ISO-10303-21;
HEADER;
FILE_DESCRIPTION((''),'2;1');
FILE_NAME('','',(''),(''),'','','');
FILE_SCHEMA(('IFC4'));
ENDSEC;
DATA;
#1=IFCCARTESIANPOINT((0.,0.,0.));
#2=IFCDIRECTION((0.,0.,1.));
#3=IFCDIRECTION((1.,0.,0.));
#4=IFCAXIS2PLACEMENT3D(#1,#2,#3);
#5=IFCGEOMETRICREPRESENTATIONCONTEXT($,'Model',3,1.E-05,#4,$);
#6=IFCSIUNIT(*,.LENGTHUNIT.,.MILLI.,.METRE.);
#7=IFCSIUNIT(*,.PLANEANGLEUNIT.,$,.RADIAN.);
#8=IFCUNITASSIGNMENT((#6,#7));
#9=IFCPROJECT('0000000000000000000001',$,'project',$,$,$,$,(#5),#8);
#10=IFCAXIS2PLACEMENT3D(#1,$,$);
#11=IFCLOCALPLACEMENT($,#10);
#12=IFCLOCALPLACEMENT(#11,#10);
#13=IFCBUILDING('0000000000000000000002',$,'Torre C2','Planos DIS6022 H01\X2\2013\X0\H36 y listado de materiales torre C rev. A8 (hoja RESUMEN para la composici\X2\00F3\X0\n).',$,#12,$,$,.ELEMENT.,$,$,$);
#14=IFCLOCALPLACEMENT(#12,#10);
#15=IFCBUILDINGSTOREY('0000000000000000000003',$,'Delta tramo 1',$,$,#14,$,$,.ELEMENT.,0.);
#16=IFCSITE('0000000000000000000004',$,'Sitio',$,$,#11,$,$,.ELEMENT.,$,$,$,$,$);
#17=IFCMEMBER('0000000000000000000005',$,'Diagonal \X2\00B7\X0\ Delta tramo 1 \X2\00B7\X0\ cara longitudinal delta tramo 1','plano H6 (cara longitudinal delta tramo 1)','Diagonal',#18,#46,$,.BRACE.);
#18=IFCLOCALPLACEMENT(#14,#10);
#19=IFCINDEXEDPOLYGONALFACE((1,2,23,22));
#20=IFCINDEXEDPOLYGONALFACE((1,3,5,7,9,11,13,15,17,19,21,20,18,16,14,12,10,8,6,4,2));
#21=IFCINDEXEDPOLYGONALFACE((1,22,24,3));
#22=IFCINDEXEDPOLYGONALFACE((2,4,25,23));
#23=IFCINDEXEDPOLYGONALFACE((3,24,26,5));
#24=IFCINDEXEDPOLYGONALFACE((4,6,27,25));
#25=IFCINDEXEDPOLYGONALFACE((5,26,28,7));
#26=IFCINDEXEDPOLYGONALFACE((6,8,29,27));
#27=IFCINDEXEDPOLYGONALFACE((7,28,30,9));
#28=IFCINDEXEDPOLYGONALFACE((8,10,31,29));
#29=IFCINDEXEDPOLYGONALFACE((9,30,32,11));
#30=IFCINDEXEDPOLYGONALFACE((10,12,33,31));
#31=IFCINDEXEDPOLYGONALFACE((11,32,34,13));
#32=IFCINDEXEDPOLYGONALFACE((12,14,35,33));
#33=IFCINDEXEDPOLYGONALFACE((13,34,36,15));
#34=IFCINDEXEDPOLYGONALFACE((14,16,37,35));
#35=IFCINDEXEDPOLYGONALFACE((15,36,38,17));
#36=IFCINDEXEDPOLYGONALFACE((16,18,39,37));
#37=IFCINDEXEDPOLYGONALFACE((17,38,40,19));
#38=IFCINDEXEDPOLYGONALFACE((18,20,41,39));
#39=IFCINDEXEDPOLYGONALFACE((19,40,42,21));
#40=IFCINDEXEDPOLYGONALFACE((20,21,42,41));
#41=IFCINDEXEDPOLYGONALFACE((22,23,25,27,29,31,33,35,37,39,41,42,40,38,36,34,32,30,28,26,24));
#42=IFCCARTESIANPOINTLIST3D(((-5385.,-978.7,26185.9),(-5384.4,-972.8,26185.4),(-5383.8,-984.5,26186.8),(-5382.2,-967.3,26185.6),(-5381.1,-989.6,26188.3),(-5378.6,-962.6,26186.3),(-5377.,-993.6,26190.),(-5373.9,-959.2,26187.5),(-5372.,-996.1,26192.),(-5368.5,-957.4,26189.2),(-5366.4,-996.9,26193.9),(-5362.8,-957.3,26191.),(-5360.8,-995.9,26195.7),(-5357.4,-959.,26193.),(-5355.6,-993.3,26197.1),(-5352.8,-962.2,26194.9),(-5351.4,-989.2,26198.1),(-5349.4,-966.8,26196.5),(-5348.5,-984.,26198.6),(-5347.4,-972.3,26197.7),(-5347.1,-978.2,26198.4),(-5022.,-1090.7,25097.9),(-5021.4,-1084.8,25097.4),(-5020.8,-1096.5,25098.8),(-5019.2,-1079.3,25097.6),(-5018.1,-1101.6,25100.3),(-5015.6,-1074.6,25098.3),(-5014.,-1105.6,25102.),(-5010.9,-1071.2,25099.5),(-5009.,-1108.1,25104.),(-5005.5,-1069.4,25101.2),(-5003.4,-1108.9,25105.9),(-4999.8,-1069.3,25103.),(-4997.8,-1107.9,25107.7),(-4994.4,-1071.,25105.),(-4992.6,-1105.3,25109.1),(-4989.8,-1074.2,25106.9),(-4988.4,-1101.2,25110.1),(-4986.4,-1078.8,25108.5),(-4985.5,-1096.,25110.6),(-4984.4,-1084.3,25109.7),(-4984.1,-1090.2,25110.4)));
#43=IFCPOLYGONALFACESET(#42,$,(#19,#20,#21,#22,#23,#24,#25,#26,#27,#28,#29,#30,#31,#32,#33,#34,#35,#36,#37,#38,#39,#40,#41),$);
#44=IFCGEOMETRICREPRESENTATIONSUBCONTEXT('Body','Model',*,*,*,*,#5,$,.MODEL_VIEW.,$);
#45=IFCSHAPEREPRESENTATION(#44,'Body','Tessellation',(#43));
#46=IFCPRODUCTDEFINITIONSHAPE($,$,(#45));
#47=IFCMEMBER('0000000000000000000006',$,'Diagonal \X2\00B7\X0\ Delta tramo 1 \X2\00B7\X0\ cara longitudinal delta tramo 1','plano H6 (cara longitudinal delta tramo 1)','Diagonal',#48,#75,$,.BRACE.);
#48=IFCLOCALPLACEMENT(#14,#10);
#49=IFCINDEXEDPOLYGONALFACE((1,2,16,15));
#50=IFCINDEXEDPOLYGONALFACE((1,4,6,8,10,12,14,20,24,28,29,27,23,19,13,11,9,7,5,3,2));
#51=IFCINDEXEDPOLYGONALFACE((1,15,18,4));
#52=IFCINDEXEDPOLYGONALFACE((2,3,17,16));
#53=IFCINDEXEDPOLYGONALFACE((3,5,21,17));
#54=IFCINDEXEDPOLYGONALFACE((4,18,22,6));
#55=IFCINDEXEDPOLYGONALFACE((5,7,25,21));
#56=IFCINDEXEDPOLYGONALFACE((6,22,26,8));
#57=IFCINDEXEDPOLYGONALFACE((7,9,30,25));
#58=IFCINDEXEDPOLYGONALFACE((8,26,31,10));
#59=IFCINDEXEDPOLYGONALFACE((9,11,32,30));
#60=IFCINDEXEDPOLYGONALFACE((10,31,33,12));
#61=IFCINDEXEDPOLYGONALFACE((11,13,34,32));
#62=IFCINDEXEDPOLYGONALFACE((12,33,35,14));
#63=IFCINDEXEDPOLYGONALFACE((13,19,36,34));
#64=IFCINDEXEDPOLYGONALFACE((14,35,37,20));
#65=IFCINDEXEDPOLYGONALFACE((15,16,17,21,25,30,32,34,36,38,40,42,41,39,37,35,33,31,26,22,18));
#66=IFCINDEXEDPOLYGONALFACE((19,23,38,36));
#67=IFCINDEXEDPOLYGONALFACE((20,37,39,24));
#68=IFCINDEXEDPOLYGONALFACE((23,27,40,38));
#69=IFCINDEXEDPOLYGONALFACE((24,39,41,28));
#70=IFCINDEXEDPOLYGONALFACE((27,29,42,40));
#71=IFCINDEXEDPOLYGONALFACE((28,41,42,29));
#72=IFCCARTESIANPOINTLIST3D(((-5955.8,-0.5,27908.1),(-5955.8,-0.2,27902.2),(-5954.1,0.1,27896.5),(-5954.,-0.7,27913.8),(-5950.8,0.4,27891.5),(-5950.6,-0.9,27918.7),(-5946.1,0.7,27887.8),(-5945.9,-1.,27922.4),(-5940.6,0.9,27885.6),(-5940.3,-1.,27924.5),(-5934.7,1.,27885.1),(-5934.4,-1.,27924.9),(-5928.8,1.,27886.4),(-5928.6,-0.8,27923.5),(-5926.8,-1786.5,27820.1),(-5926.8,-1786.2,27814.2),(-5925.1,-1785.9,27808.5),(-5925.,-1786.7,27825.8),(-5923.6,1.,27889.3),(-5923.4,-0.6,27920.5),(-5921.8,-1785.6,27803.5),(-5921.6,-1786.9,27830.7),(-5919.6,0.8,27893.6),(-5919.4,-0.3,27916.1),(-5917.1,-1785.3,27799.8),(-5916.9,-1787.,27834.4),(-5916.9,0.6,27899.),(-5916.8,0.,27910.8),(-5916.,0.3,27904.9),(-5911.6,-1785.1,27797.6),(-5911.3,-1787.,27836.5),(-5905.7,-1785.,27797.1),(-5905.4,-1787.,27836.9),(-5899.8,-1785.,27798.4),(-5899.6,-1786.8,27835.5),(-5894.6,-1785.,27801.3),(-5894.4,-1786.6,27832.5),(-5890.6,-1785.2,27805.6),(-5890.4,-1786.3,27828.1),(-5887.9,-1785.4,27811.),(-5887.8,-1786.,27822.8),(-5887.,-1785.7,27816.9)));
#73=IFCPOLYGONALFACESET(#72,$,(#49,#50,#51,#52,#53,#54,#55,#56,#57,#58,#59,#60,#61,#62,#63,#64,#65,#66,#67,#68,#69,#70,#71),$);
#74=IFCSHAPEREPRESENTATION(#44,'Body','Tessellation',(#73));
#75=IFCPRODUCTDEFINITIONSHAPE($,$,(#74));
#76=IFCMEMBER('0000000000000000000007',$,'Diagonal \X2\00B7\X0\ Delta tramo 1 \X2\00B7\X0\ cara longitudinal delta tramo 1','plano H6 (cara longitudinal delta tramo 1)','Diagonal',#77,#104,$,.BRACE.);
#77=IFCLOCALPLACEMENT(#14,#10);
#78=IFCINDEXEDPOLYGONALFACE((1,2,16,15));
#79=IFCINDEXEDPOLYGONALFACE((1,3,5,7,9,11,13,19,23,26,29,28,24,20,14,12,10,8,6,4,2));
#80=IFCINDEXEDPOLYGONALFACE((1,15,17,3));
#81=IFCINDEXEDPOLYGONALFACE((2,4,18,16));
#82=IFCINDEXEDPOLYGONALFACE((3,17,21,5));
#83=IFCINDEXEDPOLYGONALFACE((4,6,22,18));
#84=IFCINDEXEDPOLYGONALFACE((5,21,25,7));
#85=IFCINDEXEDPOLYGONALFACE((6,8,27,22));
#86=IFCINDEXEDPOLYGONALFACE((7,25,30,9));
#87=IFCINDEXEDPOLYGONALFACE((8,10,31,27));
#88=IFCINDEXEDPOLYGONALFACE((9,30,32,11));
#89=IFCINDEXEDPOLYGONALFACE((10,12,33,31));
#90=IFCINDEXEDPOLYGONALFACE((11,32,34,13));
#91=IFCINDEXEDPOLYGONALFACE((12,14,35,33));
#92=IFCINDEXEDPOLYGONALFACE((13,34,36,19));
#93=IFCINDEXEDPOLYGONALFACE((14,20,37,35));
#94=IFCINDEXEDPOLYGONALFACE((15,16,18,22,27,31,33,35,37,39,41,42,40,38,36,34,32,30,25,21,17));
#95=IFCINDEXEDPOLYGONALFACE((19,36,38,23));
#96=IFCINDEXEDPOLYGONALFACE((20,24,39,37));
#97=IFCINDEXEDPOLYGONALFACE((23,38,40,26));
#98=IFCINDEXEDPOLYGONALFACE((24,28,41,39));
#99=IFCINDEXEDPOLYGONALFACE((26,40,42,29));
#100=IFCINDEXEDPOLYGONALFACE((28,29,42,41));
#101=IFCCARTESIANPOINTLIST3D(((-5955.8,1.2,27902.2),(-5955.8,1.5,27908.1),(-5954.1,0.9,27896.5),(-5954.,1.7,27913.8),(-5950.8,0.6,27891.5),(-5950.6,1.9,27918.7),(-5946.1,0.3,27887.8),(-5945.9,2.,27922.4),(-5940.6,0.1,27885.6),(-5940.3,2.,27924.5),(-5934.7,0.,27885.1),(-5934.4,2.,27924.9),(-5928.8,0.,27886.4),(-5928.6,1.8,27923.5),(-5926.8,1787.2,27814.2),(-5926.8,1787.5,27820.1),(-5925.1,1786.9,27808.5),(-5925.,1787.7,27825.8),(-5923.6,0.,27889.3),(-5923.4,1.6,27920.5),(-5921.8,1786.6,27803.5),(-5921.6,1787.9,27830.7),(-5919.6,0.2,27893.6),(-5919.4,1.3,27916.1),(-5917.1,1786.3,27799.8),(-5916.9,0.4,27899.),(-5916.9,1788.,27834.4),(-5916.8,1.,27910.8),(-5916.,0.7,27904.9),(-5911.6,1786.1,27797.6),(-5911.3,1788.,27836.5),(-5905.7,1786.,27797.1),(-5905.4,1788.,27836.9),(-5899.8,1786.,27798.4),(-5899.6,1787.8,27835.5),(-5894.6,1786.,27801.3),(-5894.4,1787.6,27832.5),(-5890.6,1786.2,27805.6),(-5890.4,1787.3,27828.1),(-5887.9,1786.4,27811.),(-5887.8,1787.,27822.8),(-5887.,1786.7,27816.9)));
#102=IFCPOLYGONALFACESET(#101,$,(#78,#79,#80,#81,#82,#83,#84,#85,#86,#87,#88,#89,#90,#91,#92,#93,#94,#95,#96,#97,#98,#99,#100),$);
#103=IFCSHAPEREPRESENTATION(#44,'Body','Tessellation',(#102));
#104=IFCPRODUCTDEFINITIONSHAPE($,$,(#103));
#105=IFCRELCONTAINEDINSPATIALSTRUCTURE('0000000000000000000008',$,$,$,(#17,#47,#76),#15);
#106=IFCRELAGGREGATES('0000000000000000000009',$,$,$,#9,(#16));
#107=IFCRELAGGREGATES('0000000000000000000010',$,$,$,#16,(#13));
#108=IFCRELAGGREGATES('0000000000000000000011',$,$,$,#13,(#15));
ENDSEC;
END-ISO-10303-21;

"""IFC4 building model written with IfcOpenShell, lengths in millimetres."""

from ifc_helpers import new_model, si_unit, frame, origin, origin_with_axes, place, context, subcontext, project, spatial, circle, extrude, element, save


model = new_model("IFC4")

# Units and contexts
model_context = context("Model", 3, precision=1e-05, world=origin_with_axes())
body_context = subcontext(model_context, "Body", "Model", "MODEL_VIEW")
ifc_project = project(units=[si_unit("LENGTHUNIT", "METRE", prefix="MILLI"), si_unit("PLANEANGLEUNIT", "RADIAN")], contexts=[model_context])

# Site, building, storey
site_placement = place(None, origin())
site = spatial("IfcSite", under=ifc_project, at=site_placement, Name="Sitio", CompositionType="ELEMENT")
building_placement = place(site_placement, origin())
building = spatial("IfcBuilding", under=site, at=building_placement, Name="Torre C2", Description="Planos DIS6022 H01–H36 y listado de materiales torre C rev. A8 (hoja RESUMEN para la composición).", CompositionType="ELEMENT")
storey_placement = place(building_placement, origin())
storey = spatial("IfcBuildingStorey", under=building, at=storey_placement, Name="Delta tramo 1", CompositionType="ELEMENT", Elevation=0.0)

# Members
member_1_placement = place(storey_placement, frame((-5366.0, -977.0, 26192.0), z_axis=(0.314991, -0.097187, -0.944106), x_axis=(0.929313, 0.233618, 0.286007)))
element("IfcMember", 1, at=member_1_placement, inside=storey, Name="Diagonal · Delta tramo 1 · cara longitudinal delta tramo 1", Description="plano H6 (cara longitudinal delta tramo 1)", ObjectType="Diagonal", PredefinedType="BRACE", context=body_context, shape_type="SweptSolid", body=[
    extrude(circle(Radius=20.0), None, (0.0, 0.0, 1.0), 1152.4),
])
for number, where, z_axis, x_axis, name in (
    (2, (-5936.0, 0.0, 27905.0), (0.016216, -0.998657, -0.049206), (0.999841, 0.01656, -0.006597), "Diagonal · Delta tramo 1 · cara longitudinal delta tramo 1"),
    (3, (-5936.0, 1.0, 27905.0), (0.016216, 0.998657, -0.049206), (0.999841, -0.01656, -0.006606), "Diagonal · Delta tramo 1 · cara longitudinal delta tramo 1"),
):
    element("IfcMember", number, at=place(storey_placement, frame(where, z_axis=z_axis, x_axis=x_axis)), inside=storey, Name=name, Description="plano H6 (cara longitudinal delta tramo 1)", ObjectType="Diagonal", PredefinedType="BRACE", context=body_context, shape_type="SweptSolid", body=[
        extrude(circle(Radius=20.0), None, (0.0, 0.0, 1.0), 1788.4),
    ])

save(model, "model.ifc")
